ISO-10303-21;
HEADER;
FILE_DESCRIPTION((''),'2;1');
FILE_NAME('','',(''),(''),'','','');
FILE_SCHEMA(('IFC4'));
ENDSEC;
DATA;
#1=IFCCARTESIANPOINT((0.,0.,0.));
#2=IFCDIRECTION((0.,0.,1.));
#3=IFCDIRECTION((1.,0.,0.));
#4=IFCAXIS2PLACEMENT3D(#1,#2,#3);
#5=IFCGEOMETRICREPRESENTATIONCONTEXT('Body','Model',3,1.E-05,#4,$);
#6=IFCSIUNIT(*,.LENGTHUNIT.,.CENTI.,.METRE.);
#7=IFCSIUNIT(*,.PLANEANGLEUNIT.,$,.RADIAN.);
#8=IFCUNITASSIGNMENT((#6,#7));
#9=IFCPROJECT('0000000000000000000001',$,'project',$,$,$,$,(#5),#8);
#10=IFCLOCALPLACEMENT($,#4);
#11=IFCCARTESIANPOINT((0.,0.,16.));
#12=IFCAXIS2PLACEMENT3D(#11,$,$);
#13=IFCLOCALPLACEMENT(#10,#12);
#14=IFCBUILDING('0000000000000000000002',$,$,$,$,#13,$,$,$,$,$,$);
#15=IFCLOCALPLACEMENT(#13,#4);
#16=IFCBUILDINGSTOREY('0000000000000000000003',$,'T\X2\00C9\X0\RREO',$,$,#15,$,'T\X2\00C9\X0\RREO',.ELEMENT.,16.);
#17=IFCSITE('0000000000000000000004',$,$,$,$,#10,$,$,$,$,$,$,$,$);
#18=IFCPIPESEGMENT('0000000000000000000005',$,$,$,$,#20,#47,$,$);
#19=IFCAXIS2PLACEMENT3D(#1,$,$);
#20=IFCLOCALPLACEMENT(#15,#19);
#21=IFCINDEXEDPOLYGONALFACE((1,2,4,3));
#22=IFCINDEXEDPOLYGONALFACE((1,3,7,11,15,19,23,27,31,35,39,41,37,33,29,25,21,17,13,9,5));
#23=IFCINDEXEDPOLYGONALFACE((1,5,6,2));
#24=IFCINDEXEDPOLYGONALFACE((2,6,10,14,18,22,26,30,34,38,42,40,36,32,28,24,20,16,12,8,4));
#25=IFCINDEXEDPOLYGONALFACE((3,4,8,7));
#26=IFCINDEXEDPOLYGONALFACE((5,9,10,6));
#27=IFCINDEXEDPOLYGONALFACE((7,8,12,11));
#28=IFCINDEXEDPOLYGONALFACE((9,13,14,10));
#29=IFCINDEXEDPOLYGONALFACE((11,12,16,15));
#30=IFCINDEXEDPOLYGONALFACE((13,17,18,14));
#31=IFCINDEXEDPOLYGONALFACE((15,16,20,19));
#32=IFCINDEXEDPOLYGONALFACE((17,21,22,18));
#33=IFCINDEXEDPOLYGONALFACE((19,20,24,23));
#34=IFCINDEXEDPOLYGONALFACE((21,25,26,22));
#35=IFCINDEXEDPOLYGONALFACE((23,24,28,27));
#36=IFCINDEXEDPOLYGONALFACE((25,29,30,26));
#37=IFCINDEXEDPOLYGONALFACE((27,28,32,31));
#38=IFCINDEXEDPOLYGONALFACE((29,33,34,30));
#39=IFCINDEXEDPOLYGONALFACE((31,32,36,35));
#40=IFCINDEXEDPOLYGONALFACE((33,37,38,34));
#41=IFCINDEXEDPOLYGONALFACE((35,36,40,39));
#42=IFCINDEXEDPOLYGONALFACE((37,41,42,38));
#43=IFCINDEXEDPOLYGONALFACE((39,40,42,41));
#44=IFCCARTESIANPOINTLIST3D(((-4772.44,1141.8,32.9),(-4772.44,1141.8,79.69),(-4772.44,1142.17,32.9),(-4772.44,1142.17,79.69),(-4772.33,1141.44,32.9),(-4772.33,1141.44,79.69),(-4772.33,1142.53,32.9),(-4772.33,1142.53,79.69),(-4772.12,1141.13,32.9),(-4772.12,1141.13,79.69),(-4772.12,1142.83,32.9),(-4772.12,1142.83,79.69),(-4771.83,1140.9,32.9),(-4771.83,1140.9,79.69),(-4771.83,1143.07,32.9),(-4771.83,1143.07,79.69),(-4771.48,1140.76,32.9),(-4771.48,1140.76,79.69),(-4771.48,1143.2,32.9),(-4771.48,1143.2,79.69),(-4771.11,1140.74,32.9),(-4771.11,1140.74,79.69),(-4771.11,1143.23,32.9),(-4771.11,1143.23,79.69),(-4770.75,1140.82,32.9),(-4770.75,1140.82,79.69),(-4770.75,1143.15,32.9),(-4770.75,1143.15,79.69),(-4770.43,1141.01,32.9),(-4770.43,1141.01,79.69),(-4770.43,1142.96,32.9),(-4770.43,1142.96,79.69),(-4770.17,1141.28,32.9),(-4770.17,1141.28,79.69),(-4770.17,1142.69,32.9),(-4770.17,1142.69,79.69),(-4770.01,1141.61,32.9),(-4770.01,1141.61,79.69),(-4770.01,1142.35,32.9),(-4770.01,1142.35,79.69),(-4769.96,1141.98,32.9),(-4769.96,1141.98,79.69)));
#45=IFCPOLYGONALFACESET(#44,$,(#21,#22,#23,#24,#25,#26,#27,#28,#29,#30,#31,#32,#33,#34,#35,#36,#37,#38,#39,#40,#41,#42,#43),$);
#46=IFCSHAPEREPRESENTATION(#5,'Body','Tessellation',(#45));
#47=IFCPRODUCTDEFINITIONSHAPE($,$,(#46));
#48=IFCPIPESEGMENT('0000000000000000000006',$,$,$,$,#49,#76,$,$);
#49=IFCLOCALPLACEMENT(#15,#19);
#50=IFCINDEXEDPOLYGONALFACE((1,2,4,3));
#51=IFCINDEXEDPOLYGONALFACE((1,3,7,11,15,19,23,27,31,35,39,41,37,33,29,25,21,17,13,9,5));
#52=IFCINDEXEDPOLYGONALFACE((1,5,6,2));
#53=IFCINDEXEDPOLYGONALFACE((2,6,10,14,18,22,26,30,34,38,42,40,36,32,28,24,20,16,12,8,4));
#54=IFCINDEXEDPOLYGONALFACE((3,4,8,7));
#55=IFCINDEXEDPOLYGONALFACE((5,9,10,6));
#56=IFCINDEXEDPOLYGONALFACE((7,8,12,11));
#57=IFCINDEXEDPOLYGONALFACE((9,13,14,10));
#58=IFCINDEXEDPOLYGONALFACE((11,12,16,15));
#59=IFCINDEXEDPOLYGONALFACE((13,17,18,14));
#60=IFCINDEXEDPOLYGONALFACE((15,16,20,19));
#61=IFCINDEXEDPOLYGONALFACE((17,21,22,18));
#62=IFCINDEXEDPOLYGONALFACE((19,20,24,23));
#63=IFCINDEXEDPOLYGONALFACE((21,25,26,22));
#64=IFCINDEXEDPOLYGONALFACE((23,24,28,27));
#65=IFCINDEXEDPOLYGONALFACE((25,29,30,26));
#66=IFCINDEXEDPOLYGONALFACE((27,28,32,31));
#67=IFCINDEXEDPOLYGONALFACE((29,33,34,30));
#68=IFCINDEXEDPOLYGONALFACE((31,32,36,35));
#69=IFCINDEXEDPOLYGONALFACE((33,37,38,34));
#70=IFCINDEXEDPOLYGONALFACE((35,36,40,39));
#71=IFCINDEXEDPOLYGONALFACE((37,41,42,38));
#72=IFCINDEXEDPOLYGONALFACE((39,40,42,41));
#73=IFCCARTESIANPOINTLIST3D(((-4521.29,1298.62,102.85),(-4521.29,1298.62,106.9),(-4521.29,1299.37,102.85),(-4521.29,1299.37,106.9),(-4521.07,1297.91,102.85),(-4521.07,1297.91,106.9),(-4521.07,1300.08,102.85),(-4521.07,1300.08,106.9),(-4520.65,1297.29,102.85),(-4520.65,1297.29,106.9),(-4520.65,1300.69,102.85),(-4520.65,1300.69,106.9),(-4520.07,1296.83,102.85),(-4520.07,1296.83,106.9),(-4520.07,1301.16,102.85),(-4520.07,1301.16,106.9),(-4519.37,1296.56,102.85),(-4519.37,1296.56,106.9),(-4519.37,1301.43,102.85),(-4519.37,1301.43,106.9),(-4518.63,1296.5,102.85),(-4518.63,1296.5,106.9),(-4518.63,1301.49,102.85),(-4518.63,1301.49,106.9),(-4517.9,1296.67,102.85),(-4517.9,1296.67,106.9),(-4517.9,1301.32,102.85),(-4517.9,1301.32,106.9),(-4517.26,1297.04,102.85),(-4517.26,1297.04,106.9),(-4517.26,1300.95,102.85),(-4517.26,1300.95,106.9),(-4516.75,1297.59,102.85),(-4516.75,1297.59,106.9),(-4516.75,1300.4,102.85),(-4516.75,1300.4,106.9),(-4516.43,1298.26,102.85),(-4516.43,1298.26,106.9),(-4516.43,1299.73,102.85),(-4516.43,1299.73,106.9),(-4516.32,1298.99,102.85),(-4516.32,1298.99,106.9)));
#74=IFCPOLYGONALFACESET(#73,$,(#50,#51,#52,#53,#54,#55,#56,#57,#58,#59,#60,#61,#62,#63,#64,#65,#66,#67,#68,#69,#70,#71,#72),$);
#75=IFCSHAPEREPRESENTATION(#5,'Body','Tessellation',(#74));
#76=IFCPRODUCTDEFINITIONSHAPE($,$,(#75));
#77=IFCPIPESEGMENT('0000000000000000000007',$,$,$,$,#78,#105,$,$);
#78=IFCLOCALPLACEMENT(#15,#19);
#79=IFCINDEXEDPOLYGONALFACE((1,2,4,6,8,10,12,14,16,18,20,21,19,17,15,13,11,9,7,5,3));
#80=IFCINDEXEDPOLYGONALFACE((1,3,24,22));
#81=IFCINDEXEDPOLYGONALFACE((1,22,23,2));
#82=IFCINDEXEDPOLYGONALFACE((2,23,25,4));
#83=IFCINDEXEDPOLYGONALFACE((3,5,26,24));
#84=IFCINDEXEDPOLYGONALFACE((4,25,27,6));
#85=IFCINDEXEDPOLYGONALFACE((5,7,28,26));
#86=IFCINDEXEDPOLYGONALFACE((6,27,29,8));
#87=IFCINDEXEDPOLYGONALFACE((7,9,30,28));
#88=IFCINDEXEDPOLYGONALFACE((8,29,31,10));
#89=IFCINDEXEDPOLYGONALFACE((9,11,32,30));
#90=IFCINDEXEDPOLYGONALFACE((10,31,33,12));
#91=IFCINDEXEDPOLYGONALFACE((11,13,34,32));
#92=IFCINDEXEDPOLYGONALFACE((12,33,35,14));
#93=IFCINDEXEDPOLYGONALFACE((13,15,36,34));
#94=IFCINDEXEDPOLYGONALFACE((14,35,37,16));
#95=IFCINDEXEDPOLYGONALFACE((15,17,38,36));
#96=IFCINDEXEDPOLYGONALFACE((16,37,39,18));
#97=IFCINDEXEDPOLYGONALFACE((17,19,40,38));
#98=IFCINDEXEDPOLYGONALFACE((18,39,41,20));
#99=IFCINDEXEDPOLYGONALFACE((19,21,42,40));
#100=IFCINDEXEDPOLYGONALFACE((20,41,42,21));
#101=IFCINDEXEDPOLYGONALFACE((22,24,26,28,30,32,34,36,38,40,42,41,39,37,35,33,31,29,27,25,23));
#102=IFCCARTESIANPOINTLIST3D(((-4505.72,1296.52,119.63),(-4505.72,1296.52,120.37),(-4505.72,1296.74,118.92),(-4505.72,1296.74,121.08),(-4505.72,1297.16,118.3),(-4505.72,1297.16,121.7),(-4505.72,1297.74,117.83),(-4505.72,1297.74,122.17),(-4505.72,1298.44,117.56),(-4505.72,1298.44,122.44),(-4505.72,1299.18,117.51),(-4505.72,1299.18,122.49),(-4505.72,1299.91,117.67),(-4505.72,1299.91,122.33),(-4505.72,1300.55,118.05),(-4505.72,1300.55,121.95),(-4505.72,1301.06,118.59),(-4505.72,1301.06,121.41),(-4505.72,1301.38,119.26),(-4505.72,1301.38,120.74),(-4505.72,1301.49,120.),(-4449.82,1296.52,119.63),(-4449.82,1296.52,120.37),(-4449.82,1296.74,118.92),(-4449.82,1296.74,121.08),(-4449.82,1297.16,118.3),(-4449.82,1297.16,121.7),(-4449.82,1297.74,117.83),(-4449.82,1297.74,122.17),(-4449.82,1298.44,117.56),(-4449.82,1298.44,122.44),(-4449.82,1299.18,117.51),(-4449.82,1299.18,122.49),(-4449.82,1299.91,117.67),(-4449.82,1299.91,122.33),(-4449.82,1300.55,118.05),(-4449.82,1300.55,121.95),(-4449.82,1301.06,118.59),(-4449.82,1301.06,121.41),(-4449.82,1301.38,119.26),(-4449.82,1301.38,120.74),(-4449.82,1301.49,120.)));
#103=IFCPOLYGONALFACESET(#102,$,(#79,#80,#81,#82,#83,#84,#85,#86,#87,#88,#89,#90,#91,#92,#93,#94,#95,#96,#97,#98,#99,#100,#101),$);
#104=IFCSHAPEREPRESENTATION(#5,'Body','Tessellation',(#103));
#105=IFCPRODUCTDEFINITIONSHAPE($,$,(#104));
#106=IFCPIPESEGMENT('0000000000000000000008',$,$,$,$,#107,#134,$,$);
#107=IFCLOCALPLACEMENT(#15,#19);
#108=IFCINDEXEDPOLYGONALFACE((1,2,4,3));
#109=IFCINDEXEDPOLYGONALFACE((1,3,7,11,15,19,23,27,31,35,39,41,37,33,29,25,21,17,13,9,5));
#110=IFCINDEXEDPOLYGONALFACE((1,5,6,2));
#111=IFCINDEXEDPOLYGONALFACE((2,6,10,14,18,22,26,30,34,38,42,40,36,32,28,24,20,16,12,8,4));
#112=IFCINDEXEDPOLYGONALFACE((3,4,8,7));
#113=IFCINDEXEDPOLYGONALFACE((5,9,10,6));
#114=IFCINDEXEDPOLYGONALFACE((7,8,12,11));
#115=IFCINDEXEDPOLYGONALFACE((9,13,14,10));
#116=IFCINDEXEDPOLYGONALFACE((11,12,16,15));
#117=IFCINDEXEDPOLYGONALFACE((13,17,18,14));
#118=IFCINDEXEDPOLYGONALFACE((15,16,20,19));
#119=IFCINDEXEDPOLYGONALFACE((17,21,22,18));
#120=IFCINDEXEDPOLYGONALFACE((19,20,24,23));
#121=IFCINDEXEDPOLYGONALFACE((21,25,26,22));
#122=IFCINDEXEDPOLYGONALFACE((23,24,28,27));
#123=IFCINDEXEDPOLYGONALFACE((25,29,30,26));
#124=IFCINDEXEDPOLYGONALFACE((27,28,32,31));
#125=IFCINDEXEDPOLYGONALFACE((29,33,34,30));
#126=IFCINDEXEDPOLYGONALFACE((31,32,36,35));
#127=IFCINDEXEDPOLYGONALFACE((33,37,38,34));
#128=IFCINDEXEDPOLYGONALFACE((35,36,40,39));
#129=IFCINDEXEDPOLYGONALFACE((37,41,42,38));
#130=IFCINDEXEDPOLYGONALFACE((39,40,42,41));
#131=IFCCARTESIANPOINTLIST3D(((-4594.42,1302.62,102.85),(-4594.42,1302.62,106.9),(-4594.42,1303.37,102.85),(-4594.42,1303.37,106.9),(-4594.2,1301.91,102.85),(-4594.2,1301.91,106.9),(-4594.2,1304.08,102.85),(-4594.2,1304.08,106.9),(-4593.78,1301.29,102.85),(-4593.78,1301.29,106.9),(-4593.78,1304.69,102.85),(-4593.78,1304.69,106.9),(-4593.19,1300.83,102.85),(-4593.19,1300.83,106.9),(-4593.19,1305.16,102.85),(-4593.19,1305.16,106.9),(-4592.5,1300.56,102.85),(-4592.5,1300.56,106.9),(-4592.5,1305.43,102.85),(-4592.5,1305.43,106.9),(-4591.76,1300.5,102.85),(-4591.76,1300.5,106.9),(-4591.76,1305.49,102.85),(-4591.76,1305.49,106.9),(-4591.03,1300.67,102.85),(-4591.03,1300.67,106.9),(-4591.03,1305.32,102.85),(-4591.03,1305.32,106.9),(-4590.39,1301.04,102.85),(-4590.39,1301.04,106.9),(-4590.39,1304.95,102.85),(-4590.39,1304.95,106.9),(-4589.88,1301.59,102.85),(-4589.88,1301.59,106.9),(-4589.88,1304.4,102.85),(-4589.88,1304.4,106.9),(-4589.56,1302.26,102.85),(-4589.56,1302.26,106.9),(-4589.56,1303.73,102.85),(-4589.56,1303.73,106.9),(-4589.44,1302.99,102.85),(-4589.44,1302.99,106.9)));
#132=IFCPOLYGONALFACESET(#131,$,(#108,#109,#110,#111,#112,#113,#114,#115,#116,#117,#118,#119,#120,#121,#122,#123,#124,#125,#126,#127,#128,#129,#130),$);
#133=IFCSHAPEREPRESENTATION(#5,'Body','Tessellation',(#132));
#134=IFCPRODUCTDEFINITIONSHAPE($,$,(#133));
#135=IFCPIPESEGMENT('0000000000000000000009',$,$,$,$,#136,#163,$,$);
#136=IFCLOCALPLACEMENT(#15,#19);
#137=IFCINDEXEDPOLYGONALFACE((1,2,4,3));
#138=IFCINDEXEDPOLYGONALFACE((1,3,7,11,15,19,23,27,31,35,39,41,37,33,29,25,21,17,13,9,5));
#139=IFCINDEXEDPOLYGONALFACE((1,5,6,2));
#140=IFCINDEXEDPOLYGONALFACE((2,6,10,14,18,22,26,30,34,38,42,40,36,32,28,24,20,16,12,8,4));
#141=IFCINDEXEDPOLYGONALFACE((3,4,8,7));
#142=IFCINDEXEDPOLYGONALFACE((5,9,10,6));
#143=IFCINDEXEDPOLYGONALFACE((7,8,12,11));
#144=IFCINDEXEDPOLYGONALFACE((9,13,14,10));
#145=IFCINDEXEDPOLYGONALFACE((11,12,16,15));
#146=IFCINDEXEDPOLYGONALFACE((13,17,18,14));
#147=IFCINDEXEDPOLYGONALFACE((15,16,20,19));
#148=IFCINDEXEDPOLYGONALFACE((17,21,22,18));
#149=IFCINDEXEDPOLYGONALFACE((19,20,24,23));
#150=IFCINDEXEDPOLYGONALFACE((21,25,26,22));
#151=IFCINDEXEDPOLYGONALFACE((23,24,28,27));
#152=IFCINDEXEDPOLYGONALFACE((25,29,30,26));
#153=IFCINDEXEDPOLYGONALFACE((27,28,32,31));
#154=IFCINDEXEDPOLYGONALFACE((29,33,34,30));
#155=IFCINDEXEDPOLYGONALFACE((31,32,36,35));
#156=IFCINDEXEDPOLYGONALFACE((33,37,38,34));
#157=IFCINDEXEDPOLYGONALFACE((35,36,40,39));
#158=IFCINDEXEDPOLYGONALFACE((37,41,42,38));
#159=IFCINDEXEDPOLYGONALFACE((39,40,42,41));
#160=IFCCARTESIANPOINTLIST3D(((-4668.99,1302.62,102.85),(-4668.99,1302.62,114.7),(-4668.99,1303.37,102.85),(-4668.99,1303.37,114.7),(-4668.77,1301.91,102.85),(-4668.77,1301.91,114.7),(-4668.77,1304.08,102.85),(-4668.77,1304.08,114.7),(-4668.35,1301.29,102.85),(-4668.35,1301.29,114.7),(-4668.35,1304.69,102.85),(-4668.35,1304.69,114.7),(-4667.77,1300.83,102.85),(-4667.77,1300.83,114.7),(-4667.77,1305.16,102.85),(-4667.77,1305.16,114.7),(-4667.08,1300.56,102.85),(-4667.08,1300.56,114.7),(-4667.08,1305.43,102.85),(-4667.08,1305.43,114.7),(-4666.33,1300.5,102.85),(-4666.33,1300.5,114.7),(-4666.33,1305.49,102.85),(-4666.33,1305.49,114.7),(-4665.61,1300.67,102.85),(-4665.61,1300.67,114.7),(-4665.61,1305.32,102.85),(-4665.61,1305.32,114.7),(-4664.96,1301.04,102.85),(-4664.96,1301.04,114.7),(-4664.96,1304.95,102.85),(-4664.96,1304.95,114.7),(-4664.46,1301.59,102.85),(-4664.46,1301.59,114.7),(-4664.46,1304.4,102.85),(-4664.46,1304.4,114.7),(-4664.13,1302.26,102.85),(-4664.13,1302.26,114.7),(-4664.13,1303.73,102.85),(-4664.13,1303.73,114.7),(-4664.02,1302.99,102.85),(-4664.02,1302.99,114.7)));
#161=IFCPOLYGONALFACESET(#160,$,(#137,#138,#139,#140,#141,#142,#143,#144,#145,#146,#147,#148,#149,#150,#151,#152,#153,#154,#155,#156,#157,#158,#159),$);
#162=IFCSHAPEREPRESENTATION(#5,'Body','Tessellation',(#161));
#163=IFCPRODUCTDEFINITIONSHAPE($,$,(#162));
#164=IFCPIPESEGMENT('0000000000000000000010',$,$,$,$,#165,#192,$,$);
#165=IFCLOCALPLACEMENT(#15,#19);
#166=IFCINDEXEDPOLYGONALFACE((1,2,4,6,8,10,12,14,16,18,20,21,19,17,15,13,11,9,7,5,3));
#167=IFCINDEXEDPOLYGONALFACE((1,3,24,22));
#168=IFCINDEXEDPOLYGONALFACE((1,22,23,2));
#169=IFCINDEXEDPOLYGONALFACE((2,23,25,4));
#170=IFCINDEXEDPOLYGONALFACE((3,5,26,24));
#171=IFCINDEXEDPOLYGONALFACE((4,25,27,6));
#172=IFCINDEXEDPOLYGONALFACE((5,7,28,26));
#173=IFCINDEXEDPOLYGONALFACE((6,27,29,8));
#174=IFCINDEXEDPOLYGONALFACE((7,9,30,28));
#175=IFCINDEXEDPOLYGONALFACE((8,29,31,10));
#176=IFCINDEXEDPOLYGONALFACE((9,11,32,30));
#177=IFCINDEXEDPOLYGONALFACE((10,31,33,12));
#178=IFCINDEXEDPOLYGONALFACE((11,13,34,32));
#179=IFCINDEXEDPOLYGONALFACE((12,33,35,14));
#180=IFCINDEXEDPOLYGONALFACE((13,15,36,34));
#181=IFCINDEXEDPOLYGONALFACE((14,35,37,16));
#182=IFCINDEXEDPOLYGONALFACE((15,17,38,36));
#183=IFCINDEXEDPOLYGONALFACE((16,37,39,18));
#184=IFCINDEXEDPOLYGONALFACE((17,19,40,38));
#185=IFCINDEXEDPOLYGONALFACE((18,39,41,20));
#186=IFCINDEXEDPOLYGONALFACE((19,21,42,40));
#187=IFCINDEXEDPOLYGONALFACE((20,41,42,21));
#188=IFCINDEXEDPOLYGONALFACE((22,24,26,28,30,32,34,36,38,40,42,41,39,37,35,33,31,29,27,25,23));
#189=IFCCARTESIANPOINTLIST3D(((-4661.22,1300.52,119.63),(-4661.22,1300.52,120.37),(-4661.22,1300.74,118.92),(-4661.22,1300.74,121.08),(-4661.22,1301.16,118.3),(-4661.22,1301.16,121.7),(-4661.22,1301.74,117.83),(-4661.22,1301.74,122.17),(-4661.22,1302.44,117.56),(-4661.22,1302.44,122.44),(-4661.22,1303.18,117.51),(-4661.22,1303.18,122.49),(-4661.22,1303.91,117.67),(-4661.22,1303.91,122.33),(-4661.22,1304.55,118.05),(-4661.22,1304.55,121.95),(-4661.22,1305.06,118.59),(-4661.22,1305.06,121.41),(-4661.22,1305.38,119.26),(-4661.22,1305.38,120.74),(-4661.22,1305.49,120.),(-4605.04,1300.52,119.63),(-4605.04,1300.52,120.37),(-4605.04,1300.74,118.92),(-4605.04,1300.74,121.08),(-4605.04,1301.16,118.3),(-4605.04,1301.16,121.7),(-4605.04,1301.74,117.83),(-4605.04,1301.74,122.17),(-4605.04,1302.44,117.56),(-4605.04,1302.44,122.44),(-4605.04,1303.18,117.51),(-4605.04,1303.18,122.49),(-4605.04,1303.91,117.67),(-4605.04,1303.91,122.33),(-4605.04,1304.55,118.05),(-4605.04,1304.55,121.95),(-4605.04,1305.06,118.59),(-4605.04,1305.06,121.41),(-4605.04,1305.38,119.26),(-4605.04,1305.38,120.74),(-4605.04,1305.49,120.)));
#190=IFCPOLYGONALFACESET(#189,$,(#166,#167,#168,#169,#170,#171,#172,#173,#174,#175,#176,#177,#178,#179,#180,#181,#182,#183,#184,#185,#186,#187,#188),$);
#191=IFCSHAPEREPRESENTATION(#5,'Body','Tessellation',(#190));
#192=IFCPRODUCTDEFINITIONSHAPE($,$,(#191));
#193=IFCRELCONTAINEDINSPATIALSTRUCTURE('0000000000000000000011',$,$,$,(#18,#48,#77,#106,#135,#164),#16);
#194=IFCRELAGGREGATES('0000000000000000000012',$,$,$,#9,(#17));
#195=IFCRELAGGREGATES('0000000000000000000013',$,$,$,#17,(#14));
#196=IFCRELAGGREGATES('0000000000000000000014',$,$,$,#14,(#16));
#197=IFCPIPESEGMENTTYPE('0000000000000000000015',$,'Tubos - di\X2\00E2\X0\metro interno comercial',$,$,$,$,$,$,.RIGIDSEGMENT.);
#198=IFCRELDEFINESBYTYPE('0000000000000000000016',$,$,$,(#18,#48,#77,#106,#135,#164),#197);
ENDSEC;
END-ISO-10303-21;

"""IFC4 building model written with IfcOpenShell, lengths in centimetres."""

from ifc_helpers import new_model, si_unit, frame, origin_with_axes, origin_2d_with_axis, place, context, project, spatial, circle, extrude, type_object, element, save


model = new_model("IFC4")

# Units and contexts
model_context = context("Model", 3, precision=1e-05, world=origin_with_axes(), identifier="Body")
ifc_project = project(units=[si_unit("LENGTHUNIT", "METRE", prefix="CENTI"), si_unit("PLANEANGLEUNIT", "RADIAN")], contexts=[model_context])

# Site, building, storey
site_placement = place(None, origin_with_axes())
site = spatial("IfcSite", under=ifc_project, at=site_placement)
building_placement = place(site_placement, frame((0.0, 0.0, 16.0)))
building = spatial("IfcBuilding", under=site, at=building_placement)
storey_placement = place(building_placement, origin_with_axes())
storey = spatial("IfcBuildingStorey", under=building, at=storey_placement, Name="TÉRREO", LongName="TÉRREO", CompositionType="ELEMENT", Elevation=16.0)

# Pipe segments
pipe_segment_type = type_object("IfcPipeSegmentType", Name="Tubos - diâmetro interno comercial", PredefinedType="RIGIDSEGMENT")
pipe_segment_1_placement = place(storey_placement, frame((-4771.21, 1141.98, 79.69), z_axis=(0.0, 0.0, 1.0), x_axis=(1.0, 0.0, 0.0)))
element("IfcPipeSegment", 1, at=pipe_segment_1_placement, inside=storey, type_object=pipe_segment_type, context=model_context, shape_type="SolidModel", body=[
    extrude(circle(Radius=1.25, at=origin_2d_with_axis()), frame((0.0, 0.0, 0.0), z_axis=(0.0, 0.0, -1.0), x_axis=(1.0, 0.0, 0.0)), (0.0, 0.0, 1.0), 46.79),
])
pipe_segment_2_placement = place(storey_placement, frame((-4518.82, 1298.99, 106.9), z_axis=(0.0, 0.0, 1.0), x_axis=(1.0, 0.0, 0.0)))
element("IfcPipeSegment", 2, at=pipe_segment_2_placement, inside=storey, type_object=pipe_segment_type, context=model_context, shape_type="SolidModel", body=[
    extrude(circle(Radius=2.5, at=origin_2d_with_axis()), frame((0.0, 0.0, 0.0), z_axis=(0.0, 0.0, -1.0), x_axis=(1.0, 0.0, 0.0)), (0.0, 0.0, 1.0), 4.05),
])
pipe_segment_3_placement = place(storey_placement, frame((-4477.77, 1298.99, 122.5), z_axis=(0.0, 0.0, 1.0), x_axis=(1.0, 0.0, 0.0)))
element("IfcPipeSegment", 3, at=pipe_segment_3_placement, inside=storey, type_object=pipe_segment_type, context=model_context, shape_type="SolidModel", body=[
    extrude(circle(Radius=2.5, at=origin_2d_with_axis()), frame((27.95, 0.0, -2.5), z_axis=(-1.0, 0.0, 0.0), x_axis=(0.0, 1.0, 0.0)), (0.0, 0.0, 1.0), 55.9),
])
pipe_segment_4_placement = place(storey_placement, frame((-4591.94, 1302.99, 106.9), z_axis=(0.0, 0.0, 1.0), x_axis=(1.0, 0.0, 0.0)))
element("IfcPipeSegment", 4, at=pipe_segment_4_placement, inside=storey, type_object=pipe_segment_type, context=model_context, shape_type="SolidModel", body=[
    extrude(circle(Radius=2.5, at=origin_2d_with_axis()), frame((0.0, 0.0, 0.0), z_axis=(0.0, 0.0, -1.0), x_axis=(1.0, 0.0, 0.0)), (0.0, 0.0, 1.0), 4.05),
])
pipe_segment_5_placement = place(storey_placement, frame((-4666.52, 1302.99, 114.7), z_axis=(0.0, 0.0, 1.0), x_axis=(1.0, 0.0, 0.0)))
element("IfcPipeSegment", 5, at=pipe_segment_5_placement, inside=storey, type_object=pipe_segment_type, context=model_context, shape_type="SolidModel", body=[
    extrude(circle(Radius=2.5, at=origin_2d_with_axis()), frame((0.0, 0.0, 0.0), z_axis=(0.0, 0.0, -1.0), x_axis=(1.0, 0.0, 0.0)), (0.0, 0.0, 1.0), 11.85),
])
pipe_segment_6_placement = place(storey_placement, frame((-4633.13, 1302.99, 122.5), z_axis=(0.0, 0.0, 1.0), x_axis=(1.0, 0.0, 0.0)))
element("IfcPipeSegment", 6, at=pipe_segment_6_placement, inside=storey, type_object=pipe_segment_type, context=model_context, shape_type="SolidModel", body=[
    extrude(circle(Radius=2.5, at=origin_2d_with_axis()), frame((-28.09, 0.0, -2.5), z_axis=(1.0, 0.0, 0.0), x_axis=(0.0, 1.0, 0.0)), (0.0, 0.0, 1.0), 56.18),
])

save(model, "model.ifc")
